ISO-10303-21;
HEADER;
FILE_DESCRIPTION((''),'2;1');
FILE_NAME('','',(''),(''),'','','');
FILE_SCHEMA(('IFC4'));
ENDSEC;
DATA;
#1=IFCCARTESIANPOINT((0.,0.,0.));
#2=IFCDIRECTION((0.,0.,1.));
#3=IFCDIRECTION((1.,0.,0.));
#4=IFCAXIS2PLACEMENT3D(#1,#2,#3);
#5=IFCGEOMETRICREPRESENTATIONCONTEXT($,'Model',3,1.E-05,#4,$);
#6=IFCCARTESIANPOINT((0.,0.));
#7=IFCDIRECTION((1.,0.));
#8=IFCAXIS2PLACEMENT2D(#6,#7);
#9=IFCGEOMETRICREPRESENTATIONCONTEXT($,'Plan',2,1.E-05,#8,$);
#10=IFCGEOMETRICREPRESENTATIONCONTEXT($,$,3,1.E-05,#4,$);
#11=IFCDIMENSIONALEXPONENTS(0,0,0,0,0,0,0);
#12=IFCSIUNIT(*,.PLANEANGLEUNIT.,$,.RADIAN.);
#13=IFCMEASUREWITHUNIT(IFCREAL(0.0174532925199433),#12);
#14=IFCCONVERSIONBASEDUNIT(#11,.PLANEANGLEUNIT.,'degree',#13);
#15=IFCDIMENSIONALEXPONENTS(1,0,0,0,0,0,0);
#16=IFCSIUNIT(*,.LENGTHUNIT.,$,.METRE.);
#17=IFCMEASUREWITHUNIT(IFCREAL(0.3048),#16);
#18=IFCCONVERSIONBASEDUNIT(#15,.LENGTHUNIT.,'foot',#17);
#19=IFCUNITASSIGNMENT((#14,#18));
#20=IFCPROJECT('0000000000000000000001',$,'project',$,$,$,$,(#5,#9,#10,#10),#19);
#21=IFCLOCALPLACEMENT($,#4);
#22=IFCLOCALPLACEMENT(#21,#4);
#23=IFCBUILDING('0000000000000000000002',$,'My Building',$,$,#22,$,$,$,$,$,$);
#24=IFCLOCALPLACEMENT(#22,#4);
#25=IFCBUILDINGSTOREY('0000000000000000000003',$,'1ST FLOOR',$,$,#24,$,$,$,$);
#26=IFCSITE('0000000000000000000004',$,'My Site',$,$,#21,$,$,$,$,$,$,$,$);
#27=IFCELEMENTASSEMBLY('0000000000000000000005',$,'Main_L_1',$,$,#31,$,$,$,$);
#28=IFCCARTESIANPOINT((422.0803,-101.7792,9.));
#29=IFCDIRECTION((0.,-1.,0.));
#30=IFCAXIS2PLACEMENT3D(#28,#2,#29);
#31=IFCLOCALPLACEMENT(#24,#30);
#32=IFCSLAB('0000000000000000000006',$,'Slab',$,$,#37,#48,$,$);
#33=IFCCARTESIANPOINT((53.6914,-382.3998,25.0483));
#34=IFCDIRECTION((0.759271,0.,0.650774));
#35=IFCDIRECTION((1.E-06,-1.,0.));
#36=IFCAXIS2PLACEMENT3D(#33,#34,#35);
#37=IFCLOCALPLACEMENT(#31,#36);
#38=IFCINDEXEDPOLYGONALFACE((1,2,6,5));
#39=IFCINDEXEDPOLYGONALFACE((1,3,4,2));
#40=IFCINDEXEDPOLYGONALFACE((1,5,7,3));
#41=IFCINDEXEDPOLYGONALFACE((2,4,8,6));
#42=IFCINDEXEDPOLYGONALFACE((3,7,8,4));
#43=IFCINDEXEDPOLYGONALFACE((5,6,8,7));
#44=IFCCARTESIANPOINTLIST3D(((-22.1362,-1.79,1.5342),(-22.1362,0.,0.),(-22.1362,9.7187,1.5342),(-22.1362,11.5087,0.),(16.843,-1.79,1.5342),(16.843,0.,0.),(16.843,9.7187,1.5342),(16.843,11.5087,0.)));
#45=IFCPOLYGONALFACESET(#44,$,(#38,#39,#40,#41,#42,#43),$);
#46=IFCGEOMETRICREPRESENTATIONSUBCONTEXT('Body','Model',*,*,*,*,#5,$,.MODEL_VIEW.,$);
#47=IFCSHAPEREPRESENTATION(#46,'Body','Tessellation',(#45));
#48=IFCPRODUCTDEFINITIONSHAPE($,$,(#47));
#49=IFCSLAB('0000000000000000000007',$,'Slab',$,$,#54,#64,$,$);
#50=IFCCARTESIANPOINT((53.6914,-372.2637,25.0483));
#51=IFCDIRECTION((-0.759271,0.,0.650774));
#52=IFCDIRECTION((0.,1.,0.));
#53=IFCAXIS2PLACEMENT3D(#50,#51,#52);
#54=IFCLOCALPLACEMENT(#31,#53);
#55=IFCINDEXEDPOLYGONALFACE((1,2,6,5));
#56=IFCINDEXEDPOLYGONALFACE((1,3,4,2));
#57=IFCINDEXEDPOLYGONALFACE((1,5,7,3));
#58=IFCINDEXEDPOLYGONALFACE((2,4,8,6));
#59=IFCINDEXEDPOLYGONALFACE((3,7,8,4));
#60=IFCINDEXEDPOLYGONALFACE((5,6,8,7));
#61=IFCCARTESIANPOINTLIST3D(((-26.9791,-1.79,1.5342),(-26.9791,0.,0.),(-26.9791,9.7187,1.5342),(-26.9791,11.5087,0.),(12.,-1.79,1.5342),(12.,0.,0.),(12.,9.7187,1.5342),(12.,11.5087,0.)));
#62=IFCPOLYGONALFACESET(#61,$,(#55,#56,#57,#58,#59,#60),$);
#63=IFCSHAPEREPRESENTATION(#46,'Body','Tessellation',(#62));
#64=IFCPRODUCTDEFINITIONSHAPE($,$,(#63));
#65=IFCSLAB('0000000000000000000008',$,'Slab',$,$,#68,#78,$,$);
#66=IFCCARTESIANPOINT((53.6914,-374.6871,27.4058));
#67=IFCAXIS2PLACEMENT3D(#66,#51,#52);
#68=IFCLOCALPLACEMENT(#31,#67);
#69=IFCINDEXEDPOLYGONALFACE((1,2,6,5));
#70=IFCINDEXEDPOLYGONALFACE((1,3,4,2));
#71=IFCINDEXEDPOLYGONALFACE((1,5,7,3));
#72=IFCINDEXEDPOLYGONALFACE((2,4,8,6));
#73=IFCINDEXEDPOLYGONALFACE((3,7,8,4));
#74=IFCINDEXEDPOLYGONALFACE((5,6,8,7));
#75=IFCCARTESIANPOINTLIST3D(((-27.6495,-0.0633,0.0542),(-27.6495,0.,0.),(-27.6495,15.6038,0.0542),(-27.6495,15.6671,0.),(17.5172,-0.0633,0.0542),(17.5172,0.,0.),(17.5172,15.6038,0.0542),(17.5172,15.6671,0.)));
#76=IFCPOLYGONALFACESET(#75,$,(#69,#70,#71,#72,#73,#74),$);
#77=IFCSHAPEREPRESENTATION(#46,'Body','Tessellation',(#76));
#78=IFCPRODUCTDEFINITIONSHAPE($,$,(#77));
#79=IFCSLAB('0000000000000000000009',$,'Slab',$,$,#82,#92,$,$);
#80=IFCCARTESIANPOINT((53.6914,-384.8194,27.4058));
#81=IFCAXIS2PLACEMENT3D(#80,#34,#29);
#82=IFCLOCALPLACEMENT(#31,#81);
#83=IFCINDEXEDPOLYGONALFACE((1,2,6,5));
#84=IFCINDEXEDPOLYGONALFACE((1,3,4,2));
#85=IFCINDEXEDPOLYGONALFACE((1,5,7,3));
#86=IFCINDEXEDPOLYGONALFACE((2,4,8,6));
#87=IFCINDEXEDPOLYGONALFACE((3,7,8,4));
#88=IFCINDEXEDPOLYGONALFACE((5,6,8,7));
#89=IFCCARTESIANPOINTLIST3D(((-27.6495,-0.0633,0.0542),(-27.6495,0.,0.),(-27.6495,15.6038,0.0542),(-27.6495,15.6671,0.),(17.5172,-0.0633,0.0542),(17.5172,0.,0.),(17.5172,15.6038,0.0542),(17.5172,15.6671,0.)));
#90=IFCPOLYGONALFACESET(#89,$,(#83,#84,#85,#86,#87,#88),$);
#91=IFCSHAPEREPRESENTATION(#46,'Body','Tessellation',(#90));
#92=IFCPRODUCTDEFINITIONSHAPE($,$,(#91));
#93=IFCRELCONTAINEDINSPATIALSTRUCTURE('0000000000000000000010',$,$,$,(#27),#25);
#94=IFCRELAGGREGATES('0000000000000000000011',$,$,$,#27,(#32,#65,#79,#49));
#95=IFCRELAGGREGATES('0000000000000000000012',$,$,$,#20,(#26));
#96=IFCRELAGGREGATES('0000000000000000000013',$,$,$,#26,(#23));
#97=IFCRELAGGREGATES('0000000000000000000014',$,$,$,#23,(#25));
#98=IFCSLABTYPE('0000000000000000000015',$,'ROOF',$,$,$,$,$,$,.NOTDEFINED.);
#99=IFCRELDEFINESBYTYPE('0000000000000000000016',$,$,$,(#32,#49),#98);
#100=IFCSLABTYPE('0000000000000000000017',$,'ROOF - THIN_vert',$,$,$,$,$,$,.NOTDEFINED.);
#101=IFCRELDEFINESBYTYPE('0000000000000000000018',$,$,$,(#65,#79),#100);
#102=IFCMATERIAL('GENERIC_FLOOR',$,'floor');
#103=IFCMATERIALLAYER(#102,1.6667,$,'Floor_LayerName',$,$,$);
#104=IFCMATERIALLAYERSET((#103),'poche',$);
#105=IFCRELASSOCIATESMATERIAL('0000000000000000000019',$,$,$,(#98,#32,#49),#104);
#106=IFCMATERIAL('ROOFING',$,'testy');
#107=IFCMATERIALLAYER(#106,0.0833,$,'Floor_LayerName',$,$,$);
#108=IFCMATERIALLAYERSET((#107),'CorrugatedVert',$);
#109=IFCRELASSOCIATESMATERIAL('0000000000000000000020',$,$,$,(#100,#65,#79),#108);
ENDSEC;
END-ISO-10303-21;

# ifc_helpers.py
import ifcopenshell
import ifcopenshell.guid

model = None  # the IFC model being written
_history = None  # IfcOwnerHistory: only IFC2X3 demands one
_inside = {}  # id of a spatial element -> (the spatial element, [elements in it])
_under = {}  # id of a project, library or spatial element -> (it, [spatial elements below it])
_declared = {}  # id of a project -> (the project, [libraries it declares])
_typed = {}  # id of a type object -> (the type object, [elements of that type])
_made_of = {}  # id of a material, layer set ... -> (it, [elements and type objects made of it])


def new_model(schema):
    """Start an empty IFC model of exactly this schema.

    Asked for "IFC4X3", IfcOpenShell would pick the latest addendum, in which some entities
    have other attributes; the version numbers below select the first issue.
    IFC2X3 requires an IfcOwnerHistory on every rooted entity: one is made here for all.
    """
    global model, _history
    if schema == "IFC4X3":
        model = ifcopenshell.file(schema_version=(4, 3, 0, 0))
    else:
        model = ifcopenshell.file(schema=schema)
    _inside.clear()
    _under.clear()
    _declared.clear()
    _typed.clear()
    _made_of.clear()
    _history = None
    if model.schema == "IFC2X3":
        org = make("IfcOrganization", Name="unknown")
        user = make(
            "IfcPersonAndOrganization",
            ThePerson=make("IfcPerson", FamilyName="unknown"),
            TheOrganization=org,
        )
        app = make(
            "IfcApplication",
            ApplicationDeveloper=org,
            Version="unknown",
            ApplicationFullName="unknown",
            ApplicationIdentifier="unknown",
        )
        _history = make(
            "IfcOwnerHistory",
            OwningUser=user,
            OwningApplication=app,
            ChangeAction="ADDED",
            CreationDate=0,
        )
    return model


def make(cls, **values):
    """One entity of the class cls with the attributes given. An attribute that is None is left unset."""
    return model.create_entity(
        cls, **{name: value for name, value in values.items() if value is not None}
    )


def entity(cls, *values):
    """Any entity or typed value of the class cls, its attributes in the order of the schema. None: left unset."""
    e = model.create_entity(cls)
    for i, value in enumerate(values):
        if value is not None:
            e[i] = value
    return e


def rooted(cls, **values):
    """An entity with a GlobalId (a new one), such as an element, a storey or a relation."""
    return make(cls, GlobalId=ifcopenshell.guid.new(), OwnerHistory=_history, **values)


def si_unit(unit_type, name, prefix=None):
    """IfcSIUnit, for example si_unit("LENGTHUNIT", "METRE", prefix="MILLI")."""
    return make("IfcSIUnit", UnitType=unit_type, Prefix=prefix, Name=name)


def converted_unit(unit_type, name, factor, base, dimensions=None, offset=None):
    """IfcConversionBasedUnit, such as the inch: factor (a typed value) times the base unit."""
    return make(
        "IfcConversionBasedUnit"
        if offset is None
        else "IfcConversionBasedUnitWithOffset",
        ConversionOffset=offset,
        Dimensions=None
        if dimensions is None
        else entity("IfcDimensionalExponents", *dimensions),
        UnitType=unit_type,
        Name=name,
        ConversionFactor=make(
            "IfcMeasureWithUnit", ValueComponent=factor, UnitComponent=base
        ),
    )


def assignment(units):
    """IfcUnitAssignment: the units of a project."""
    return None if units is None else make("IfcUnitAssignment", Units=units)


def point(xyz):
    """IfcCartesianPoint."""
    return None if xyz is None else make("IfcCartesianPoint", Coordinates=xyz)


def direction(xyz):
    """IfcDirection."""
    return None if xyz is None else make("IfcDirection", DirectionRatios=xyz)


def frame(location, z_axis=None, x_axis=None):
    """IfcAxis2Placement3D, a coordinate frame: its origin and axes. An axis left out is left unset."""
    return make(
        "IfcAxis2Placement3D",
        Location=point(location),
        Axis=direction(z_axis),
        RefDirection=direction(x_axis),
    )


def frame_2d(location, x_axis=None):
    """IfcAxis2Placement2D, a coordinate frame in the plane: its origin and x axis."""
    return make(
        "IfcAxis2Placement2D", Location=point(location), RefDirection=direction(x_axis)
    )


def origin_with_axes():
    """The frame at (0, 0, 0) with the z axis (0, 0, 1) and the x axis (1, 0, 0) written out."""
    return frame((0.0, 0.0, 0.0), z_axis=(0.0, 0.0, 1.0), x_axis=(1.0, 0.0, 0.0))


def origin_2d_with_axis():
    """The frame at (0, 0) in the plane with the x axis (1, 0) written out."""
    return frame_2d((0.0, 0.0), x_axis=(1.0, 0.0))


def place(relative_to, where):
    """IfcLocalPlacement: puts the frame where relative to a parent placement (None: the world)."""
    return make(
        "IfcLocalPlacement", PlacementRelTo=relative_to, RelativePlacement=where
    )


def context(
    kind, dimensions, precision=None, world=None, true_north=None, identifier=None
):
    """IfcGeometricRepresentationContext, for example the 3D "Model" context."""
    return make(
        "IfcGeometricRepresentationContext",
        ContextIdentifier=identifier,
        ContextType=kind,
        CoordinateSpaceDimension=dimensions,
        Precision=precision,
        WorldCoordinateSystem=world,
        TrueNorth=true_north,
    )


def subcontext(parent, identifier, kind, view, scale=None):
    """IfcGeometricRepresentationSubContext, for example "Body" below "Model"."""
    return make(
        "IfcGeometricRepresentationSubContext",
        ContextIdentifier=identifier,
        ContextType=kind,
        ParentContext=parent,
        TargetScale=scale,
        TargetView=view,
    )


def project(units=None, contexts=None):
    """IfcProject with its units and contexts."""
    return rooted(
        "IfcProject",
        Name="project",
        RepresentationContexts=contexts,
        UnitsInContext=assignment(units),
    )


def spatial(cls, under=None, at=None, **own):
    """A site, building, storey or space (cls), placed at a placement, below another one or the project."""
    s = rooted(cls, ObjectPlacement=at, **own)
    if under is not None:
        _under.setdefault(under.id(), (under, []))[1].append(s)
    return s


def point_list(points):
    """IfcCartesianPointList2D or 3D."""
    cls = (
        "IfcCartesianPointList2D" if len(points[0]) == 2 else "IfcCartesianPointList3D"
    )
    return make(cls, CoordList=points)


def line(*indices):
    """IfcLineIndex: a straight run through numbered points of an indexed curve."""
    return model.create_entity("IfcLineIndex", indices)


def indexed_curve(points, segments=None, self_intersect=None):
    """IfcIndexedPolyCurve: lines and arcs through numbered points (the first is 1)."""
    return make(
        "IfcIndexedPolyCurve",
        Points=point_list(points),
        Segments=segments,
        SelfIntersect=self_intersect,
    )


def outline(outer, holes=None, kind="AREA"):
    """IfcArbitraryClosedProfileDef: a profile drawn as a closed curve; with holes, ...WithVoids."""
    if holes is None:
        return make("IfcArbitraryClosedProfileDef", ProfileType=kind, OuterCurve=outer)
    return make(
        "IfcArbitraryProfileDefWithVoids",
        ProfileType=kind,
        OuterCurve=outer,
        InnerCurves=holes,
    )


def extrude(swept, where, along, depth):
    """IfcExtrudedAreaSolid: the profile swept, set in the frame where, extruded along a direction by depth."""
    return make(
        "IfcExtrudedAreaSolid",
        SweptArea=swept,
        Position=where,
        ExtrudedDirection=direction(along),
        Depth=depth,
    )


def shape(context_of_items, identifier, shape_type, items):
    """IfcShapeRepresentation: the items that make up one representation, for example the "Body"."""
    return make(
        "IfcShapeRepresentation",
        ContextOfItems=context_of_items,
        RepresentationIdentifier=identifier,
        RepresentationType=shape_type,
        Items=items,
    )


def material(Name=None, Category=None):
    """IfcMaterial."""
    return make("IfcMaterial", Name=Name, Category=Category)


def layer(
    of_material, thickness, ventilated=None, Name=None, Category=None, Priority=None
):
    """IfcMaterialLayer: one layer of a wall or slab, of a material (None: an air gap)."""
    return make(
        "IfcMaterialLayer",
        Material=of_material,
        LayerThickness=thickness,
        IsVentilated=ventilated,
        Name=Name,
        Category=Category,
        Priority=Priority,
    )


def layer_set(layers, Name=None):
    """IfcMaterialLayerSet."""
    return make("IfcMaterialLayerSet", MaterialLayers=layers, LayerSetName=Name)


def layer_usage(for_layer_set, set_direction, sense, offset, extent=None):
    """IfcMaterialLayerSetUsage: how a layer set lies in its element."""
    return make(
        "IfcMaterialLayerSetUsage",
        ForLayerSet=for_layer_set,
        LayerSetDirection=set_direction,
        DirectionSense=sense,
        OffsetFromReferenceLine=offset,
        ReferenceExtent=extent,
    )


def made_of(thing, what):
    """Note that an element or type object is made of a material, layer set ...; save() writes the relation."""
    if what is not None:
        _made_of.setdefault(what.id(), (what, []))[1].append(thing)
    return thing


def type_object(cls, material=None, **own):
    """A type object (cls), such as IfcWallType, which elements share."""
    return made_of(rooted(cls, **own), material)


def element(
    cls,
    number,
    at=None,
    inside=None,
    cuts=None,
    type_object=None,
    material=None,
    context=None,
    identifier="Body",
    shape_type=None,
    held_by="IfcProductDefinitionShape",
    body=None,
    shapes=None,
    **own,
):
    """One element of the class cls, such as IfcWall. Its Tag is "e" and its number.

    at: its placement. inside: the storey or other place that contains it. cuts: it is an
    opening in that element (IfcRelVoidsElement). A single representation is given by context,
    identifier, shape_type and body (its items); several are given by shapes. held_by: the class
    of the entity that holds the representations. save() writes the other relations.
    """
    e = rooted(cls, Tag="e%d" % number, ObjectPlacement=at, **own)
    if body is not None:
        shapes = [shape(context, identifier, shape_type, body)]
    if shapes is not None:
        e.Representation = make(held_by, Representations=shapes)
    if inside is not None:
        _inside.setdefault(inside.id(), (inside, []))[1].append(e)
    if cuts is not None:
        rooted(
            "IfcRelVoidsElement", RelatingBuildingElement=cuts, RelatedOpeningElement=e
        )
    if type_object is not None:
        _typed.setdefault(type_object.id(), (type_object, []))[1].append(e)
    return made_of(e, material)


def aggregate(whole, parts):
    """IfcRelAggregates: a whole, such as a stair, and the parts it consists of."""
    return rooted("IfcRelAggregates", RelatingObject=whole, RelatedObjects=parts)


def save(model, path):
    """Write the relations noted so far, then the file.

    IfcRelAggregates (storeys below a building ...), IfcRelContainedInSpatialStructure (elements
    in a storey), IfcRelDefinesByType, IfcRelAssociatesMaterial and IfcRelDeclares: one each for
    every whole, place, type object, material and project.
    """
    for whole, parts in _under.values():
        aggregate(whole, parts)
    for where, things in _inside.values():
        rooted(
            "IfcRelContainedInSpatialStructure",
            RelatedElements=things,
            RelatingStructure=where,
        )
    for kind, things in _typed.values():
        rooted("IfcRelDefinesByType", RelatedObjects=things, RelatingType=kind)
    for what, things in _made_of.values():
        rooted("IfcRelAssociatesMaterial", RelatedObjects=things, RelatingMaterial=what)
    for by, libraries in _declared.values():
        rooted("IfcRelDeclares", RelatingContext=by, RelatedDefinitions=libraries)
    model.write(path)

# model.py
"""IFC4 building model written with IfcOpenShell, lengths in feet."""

from ifc_helpers import new_model, entity, si_unit, converted_unit, frame, origin_with_axes, origin_2d_with_axis, place, context, subcontext, project, spatial, line, indexed_curve, outline, extrude, material, layer, layer_set, layer_usage, type_object, element, aggregate, save


model = new_model("IFC4")

# Units and contexts
model_context = context("Model", 3, precision=1e-05, world=origin_with_axes())
plan_context = context("Plan", 2, precision=1e-05, world=origin_2d_with_axis())
context_of_model = context(None, 3, precision=1e-05, world=origin_with_axes())
body_context = subcontext(model_context, "Body", "Model", "MODEL_VIEW")
ifc_project = project(units=[converted_unit("PLANEANGLEUNIT", "degree", entity("IfcReal", 0.0174532925199433), si_unit("PLANEANGLEUNIT", "RADIAN"), dimensions=[0, 0, 0, 0, 0, 0, 0]), converted_unit("LENGTHUNIT", "foot", entity("IfcReal", 0.3048), si_unit("LENGTHUNIT", "METRE"), dimensions=[1, 0, 0, 0, 0, 0, 0])], contexts=[model_context, plan_context, context_of_model, context_of_model])

# Site, building, storey
site_placement = place(None, origin_with_axes())
site = spatial("IfcSite", under=ifc_project, at=site_placement, Name="My Site")
building_placement = place(site_placement, origin_with_axes())
building = spatial("IfcBuilding", under=site, at=building_placement, Name="My Building")
storey_placement = place(building_placement, origin_with_axes())
storey = spatial("IfcBuildingStorey", under=building, at=storey_placement, Name="1ST FLOOR")

# Element assembly, slabs
assembly_placement = place(storey_placement, frame((422.0803, -101.7792, 9.0), z_axis=(0.0, 0.0, 1.0), x_axis=(0.0, -1.0, 0.0)))
assembly = element("IfcElementAssembly", 1, at=assembly_placement, inside=storey, Name="Main_L_1")
ifc_material_1 = material(Name="GENERIC_FLOOR", Category="floor")
ifc_layer_1 = layer(ifc_material_1, 1.6667, Name="Floor_LayerName")
ifc_layer_set_1 = layer_set([ifc_layer_1], Name="poche")
ifc_layer_usage_1 = layer_usage(ifc_layer_set_1, "AXIS3", "POSITIVE", 0.0)
slab_type_1 = type_object("IfcSlabType", Name="ROOF", PredefinedType="NOTDEFINED", material=ifc_layer_set_1)
slab_1_placement = place(assembly_placement, frame((53.6914, -382.3998, 25.0483), z_axis=(0.759271, 0.0, 0.650774), x_axis=(0.000001, -1.0, 0.0)))
slab_1 = element("IfcSlab", 2, at=slab_1_placement, type_object=slab_type_1, material=ifc_layer_usage_1, Name="Slab", context=body_context, shape_type="SweptSolid", body=[
    extrude(outline(indexed_curve([(-22.1362, 0.0), (-22.1362, 11.5087), (16.843, 11.5087), (16.843, 0.0)], segments=[line(3, 2), line(2, 1), line(1, 4), line(4, 3)], self_intersect=False)), None, (0.0, -0.759271, 0.650774), 2.3575),
])
ifc_layer_usage_2 = layer_usage(ifc_layer_set_1, "AXIS3", "POSITIVE", 0.0)
slab_2_placement = place(assembly_placement, frame((53.6914, -372.2637, 25.0483), z_axis=(-0.759271, 0.0, 0.650774), x_axis=(0.0, 1.0, 0.0)))
slab_2 = element("IfcSlab", 3, at=slab_2_placement, type_object=slab_type_1, material=ifc_layer_usage_2, Name="Slab", context=body_context, shape_type="SweptSolid", body=[
    extrude(outline(indexed_curve([(-26.9791, 11.5087), (-26.9791, 0.0), (12.0, 0.0), (12.0, 11.5087)], segments=[line(3, 2), line(2, 1), line(1, 4), line(4, 3)], self_intersect=False)), None, (0.0, -0.759271, 0.650774), 2.3575),
])
ifc_material_2 = material(Name="ROOFING", Category="testy")
ifc_layer_2 = layer(ifc_material_2, 0.0833, Name="Floor_LayerName")
ifc_layer_set_2 = layer_set([ifc_layer_2], Name="CorrugatedVert")
ifc_layer_usage_3 = layer_usage(ifc_layer_set_2, "AXIS3", "POSITIVE", 0.0)
slab_type_2 = type_object("IfcSlabType", Name="ROOF - THIN_vert", PredefinedType="NOTDEFINED", material=ifc_layer_set_2)
slab_3_placement = place(assembly_placement, frame((53.6914, -374.6871, 27.4058), z_axis=(-0.759271, 0.0, 0.650774), x_axis=(0.0, 1.0, 0.0)))
slab_3 = element("IfcSlab", 4, at=slab_3_placement, type_object=slab_type_2, material=ifc_layer_usage_3, Name="Slab", context=body_context, shape_type="SweptSolid", body=[
    extrude(outline(indexed_curve([(17.5172, 15.6671), (-27.6495, 15.6671), (-27.6495, 0.0), (17.5172, 0.0)], segments=[line(4, 1), line(1, 2), line(2, 3), line(3, 4)], self_intersect=False)), None, (0.0, -0.759271, 0.650774), 0.0833),
])
ifc_layer_usage_4 = layer_usage(ifc_layer_set_2, "AXIS3", "POSITIVE", 0.0)
slab_4_placement = place(assembly_placement, frame((53.6914, -384.8194, 27.4058), z_axis=(0.759271, 0.0, 0.650774), x_axis=(0.0, -1.0, 0.0)))
slab_4 = element("IfcSlab", 5, at=slab_4_placement, type_object=slab_type_2, material=ifc_layer_usage_4, Name="Slab", context=body_context, shape_type="SweptSolid", body=[
    extrude(outline(indexed_curve([(17.5172, 15.6671), (-27.6495, 15.6671), (-27.6495, 0.0), (17.5172, 0.0)], segments=[line(4, 1), line(1, 2), line(2, 3), line(3, 4)], self_intersect=False)), None, (0.0, -0.759271, 0.650774), 0.0833),
])
aggregate(assembly, [slab_1, slab_3, slab_4, slab_2])

save(model, "model.ifc")
